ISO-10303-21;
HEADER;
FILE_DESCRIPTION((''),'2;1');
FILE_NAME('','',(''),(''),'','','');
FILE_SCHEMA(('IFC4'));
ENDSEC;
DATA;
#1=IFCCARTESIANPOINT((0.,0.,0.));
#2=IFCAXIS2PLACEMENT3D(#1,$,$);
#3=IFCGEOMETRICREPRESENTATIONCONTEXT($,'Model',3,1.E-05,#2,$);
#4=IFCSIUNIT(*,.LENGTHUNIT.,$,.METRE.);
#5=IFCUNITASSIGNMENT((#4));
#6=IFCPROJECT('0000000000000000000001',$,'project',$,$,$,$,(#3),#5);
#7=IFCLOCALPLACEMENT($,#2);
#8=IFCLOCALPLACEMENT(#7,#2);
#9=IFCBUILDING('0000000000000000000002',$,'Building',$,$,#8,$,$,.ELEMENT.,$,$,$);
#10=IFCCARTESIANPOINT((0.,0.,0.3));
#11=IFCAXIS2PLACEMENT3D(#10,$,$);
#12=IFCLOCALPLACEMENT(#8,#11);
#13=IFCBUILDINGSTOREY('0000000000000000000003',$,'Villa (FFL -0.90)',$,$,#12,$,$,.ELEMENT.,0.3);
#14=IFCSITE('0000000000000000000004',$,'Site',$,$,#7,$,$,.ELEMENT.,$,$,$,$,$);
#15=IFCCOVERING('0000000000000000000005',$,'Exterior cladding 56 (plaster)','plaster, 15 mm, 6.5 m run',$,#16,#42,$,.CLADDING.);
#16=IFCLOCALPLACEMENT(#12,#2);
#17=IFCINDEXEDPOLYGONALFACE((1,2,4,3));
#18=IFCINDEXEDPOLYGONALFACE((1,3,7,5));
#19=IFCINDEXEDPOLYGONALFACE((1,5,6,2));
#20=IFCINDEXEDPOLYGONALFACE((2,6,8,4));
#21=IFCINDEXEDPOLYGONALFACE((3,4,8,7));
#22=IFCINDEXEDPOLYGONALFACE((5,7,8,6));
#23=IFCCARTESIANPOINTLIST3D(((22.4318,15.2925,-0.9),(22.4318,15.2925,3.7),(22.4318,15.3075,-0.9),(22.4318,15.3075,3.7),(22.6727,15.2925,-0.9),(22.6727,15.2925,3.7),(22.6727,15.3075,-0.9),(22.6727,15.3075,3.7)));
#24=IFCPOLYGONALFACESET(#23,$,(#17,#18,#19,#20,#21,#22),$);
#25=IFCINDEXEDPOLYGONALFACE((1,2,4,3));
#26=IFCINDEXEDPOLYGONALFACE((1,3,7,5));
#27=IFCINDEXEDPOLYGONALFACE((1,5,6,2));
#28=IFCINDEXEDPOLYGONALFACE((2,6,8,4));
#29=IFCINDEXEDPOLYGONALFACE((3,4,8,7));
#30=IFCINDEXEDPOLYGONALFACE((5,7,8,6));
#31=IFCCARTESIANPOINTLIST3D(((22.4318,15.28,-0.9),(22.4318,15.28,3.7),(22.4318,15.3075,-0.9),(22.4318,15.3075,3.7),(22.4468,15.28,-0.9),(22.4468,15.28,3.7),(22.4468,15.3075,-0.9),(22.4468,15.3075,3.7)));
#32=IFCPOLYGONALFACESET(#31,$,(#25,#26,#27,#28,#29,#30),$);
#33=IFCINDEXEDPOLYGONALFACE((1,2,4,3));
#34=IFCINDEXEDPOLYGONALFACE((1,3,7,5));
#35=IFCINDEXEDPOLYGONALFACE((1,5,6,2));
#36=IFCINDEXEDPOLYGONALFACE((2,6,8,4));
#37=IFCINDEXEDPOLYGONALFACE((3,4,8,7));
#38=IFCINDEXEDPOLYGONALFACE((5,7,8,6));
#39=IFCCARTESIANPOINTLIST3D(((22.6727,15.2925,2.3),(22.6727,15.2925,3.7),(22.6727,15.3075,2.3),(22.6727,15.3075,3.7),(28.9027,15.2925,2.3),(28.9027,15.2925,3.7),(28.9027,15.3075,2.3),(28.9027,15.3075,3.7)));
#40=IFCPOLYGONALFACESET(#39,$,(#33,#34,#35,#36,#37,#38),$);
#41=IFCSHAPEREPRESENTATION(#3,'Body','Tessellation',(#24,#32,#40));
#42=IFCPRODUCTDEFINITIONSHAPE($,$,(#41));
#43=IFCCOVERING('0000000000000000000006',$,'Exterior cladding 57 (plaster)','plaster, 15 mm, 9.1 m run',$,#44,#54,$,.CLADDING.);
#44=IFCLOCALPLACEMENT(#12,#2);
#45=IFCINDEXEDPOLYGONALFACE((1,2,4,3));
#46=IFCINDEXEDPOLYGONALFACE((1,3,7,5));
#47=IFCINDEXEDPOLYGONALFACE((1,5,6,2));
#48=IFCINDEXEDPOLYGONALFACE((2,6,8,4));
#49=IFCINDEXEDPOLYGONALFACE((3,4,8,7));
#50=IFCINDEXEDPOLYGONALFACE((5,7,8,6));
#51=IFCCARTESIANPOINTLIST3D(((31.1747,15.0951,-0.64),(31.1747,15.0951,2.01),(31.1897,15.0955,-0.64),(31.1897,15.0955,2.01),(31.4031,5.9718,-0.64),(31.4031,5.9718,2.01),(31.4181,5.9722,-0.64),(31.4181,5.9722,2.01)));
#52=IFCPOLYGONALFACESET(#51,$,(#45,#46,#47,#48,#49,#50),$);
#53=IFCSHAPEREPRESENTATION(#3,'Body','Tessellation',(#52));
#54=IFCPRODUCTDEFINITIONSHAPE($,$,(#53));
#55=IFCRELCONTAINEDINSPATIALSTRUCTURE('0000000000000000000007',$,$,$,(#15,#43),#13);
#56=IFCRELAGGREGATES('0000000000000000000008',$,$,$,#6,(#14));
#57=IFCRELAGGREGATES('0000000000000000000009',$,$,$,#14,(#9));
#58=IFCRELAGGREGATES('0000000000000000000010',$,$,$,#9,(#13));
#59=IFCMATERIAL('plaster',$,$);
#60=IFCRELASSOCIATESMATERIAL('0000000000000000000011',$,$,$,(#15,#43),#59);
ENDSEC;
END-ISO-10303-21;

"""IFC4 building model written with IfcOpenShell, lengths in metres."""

from ifc_helpers import new_model, si_unit, frame, origin, origin_with_axes, place, context, project, spatial, polyline, outline, extrude, material, element, save


model = new_model("IFC4")

# Units and contexts
model_context = context("Model", 3, precision=1e-05, world=origin())
ifc_project = project(units=[si_unit("LENGTHUNIT", "METRE")], contexts=[model_context])

# Site, building, storey
site_placement = place(None, origin())
site = spatial("IfcSite", under=ifc_project, at=site_placement, Name="Site", CompositionType="ELEMENT")
building_placement = place(site_placement, origin())
building = spatial("IfcBuilding", under=site, at=building_placement, Name="Building", CompositionType="ELEMENT")
storey_placement = place(building_placement, frame((0.0, 0.0, 0.3)))
storey = spatial("IfcBuildingStorey", under=building, at=storey_placement, Name="Villa (FFL -0.90)", CompositionType="ELEMENT", Elevation=0.3)

# Coverings
ifc_material = material(Name="plaster")
covering_1_placement = place(storey_placement, origin_with_axes())
element("IfcCovering", 1, at=covering_1_placement, inside=storey, material=ifc_material, Name="Exterior cladding 56 (plaster)", Description="plaster, 15 mm, 6.5 m run", PredefinedType="CLADDING", context=model_context, shape_type="SweptSolid", body=[
    extrude(outline(polyline([(22.6727, 15.3075), (22.4318, 15.3075), (22.4318, 15.2925), (22.6727, 15.2925), (22.6727, 15.3075)])), frame((0.0, 0.0, -0.9)), (0.0, 0.0, 1.0), 4.6),
    extrude(outline(polyline([(22.4318, 15.3075), (22.4318, 15.28), (22.4468, 15.28), (22.4468, 15.3075), (22.4318, 15.3075)])), frame((0.0, 0.0, -0.9)), (0.0, 0.0, 1.0), 4.6),
    extrude(outline(polyline([(28.9027, 15.3075), (22.6727, 15.3075), (22.6727, 15.2925), (28.9027, 15.2925), (28.9027, 15.3075)])), frame((0.0, 0.0, 2.3)), (0.0, 0.0, 1.0), 1.4),
])
covering_2_placement = place(storey_placement, origin_with_axes())
element("IfcCovering", 2, at=covering_2_placement, inside=storey, material=ifc_material, Name="Exterior cladding 57 (plaster)", Description="plaster, 15 mm, 9.1 m run", PredefinedType="CLADDING", context=model_context, shape_type="SweptSolid", body=[
    extrude(outline(polyline([(31.1747, 15.0951), (31.4031, 5.9718), (31.4181, 5.9722), (31.1897, 15.0955), (31.1747, 15.0951)])), frame((0.0, 0.0, -0.64)), (0.0, 0.0, 1.0), 2.65),
])

save(model, "model.ifc")
